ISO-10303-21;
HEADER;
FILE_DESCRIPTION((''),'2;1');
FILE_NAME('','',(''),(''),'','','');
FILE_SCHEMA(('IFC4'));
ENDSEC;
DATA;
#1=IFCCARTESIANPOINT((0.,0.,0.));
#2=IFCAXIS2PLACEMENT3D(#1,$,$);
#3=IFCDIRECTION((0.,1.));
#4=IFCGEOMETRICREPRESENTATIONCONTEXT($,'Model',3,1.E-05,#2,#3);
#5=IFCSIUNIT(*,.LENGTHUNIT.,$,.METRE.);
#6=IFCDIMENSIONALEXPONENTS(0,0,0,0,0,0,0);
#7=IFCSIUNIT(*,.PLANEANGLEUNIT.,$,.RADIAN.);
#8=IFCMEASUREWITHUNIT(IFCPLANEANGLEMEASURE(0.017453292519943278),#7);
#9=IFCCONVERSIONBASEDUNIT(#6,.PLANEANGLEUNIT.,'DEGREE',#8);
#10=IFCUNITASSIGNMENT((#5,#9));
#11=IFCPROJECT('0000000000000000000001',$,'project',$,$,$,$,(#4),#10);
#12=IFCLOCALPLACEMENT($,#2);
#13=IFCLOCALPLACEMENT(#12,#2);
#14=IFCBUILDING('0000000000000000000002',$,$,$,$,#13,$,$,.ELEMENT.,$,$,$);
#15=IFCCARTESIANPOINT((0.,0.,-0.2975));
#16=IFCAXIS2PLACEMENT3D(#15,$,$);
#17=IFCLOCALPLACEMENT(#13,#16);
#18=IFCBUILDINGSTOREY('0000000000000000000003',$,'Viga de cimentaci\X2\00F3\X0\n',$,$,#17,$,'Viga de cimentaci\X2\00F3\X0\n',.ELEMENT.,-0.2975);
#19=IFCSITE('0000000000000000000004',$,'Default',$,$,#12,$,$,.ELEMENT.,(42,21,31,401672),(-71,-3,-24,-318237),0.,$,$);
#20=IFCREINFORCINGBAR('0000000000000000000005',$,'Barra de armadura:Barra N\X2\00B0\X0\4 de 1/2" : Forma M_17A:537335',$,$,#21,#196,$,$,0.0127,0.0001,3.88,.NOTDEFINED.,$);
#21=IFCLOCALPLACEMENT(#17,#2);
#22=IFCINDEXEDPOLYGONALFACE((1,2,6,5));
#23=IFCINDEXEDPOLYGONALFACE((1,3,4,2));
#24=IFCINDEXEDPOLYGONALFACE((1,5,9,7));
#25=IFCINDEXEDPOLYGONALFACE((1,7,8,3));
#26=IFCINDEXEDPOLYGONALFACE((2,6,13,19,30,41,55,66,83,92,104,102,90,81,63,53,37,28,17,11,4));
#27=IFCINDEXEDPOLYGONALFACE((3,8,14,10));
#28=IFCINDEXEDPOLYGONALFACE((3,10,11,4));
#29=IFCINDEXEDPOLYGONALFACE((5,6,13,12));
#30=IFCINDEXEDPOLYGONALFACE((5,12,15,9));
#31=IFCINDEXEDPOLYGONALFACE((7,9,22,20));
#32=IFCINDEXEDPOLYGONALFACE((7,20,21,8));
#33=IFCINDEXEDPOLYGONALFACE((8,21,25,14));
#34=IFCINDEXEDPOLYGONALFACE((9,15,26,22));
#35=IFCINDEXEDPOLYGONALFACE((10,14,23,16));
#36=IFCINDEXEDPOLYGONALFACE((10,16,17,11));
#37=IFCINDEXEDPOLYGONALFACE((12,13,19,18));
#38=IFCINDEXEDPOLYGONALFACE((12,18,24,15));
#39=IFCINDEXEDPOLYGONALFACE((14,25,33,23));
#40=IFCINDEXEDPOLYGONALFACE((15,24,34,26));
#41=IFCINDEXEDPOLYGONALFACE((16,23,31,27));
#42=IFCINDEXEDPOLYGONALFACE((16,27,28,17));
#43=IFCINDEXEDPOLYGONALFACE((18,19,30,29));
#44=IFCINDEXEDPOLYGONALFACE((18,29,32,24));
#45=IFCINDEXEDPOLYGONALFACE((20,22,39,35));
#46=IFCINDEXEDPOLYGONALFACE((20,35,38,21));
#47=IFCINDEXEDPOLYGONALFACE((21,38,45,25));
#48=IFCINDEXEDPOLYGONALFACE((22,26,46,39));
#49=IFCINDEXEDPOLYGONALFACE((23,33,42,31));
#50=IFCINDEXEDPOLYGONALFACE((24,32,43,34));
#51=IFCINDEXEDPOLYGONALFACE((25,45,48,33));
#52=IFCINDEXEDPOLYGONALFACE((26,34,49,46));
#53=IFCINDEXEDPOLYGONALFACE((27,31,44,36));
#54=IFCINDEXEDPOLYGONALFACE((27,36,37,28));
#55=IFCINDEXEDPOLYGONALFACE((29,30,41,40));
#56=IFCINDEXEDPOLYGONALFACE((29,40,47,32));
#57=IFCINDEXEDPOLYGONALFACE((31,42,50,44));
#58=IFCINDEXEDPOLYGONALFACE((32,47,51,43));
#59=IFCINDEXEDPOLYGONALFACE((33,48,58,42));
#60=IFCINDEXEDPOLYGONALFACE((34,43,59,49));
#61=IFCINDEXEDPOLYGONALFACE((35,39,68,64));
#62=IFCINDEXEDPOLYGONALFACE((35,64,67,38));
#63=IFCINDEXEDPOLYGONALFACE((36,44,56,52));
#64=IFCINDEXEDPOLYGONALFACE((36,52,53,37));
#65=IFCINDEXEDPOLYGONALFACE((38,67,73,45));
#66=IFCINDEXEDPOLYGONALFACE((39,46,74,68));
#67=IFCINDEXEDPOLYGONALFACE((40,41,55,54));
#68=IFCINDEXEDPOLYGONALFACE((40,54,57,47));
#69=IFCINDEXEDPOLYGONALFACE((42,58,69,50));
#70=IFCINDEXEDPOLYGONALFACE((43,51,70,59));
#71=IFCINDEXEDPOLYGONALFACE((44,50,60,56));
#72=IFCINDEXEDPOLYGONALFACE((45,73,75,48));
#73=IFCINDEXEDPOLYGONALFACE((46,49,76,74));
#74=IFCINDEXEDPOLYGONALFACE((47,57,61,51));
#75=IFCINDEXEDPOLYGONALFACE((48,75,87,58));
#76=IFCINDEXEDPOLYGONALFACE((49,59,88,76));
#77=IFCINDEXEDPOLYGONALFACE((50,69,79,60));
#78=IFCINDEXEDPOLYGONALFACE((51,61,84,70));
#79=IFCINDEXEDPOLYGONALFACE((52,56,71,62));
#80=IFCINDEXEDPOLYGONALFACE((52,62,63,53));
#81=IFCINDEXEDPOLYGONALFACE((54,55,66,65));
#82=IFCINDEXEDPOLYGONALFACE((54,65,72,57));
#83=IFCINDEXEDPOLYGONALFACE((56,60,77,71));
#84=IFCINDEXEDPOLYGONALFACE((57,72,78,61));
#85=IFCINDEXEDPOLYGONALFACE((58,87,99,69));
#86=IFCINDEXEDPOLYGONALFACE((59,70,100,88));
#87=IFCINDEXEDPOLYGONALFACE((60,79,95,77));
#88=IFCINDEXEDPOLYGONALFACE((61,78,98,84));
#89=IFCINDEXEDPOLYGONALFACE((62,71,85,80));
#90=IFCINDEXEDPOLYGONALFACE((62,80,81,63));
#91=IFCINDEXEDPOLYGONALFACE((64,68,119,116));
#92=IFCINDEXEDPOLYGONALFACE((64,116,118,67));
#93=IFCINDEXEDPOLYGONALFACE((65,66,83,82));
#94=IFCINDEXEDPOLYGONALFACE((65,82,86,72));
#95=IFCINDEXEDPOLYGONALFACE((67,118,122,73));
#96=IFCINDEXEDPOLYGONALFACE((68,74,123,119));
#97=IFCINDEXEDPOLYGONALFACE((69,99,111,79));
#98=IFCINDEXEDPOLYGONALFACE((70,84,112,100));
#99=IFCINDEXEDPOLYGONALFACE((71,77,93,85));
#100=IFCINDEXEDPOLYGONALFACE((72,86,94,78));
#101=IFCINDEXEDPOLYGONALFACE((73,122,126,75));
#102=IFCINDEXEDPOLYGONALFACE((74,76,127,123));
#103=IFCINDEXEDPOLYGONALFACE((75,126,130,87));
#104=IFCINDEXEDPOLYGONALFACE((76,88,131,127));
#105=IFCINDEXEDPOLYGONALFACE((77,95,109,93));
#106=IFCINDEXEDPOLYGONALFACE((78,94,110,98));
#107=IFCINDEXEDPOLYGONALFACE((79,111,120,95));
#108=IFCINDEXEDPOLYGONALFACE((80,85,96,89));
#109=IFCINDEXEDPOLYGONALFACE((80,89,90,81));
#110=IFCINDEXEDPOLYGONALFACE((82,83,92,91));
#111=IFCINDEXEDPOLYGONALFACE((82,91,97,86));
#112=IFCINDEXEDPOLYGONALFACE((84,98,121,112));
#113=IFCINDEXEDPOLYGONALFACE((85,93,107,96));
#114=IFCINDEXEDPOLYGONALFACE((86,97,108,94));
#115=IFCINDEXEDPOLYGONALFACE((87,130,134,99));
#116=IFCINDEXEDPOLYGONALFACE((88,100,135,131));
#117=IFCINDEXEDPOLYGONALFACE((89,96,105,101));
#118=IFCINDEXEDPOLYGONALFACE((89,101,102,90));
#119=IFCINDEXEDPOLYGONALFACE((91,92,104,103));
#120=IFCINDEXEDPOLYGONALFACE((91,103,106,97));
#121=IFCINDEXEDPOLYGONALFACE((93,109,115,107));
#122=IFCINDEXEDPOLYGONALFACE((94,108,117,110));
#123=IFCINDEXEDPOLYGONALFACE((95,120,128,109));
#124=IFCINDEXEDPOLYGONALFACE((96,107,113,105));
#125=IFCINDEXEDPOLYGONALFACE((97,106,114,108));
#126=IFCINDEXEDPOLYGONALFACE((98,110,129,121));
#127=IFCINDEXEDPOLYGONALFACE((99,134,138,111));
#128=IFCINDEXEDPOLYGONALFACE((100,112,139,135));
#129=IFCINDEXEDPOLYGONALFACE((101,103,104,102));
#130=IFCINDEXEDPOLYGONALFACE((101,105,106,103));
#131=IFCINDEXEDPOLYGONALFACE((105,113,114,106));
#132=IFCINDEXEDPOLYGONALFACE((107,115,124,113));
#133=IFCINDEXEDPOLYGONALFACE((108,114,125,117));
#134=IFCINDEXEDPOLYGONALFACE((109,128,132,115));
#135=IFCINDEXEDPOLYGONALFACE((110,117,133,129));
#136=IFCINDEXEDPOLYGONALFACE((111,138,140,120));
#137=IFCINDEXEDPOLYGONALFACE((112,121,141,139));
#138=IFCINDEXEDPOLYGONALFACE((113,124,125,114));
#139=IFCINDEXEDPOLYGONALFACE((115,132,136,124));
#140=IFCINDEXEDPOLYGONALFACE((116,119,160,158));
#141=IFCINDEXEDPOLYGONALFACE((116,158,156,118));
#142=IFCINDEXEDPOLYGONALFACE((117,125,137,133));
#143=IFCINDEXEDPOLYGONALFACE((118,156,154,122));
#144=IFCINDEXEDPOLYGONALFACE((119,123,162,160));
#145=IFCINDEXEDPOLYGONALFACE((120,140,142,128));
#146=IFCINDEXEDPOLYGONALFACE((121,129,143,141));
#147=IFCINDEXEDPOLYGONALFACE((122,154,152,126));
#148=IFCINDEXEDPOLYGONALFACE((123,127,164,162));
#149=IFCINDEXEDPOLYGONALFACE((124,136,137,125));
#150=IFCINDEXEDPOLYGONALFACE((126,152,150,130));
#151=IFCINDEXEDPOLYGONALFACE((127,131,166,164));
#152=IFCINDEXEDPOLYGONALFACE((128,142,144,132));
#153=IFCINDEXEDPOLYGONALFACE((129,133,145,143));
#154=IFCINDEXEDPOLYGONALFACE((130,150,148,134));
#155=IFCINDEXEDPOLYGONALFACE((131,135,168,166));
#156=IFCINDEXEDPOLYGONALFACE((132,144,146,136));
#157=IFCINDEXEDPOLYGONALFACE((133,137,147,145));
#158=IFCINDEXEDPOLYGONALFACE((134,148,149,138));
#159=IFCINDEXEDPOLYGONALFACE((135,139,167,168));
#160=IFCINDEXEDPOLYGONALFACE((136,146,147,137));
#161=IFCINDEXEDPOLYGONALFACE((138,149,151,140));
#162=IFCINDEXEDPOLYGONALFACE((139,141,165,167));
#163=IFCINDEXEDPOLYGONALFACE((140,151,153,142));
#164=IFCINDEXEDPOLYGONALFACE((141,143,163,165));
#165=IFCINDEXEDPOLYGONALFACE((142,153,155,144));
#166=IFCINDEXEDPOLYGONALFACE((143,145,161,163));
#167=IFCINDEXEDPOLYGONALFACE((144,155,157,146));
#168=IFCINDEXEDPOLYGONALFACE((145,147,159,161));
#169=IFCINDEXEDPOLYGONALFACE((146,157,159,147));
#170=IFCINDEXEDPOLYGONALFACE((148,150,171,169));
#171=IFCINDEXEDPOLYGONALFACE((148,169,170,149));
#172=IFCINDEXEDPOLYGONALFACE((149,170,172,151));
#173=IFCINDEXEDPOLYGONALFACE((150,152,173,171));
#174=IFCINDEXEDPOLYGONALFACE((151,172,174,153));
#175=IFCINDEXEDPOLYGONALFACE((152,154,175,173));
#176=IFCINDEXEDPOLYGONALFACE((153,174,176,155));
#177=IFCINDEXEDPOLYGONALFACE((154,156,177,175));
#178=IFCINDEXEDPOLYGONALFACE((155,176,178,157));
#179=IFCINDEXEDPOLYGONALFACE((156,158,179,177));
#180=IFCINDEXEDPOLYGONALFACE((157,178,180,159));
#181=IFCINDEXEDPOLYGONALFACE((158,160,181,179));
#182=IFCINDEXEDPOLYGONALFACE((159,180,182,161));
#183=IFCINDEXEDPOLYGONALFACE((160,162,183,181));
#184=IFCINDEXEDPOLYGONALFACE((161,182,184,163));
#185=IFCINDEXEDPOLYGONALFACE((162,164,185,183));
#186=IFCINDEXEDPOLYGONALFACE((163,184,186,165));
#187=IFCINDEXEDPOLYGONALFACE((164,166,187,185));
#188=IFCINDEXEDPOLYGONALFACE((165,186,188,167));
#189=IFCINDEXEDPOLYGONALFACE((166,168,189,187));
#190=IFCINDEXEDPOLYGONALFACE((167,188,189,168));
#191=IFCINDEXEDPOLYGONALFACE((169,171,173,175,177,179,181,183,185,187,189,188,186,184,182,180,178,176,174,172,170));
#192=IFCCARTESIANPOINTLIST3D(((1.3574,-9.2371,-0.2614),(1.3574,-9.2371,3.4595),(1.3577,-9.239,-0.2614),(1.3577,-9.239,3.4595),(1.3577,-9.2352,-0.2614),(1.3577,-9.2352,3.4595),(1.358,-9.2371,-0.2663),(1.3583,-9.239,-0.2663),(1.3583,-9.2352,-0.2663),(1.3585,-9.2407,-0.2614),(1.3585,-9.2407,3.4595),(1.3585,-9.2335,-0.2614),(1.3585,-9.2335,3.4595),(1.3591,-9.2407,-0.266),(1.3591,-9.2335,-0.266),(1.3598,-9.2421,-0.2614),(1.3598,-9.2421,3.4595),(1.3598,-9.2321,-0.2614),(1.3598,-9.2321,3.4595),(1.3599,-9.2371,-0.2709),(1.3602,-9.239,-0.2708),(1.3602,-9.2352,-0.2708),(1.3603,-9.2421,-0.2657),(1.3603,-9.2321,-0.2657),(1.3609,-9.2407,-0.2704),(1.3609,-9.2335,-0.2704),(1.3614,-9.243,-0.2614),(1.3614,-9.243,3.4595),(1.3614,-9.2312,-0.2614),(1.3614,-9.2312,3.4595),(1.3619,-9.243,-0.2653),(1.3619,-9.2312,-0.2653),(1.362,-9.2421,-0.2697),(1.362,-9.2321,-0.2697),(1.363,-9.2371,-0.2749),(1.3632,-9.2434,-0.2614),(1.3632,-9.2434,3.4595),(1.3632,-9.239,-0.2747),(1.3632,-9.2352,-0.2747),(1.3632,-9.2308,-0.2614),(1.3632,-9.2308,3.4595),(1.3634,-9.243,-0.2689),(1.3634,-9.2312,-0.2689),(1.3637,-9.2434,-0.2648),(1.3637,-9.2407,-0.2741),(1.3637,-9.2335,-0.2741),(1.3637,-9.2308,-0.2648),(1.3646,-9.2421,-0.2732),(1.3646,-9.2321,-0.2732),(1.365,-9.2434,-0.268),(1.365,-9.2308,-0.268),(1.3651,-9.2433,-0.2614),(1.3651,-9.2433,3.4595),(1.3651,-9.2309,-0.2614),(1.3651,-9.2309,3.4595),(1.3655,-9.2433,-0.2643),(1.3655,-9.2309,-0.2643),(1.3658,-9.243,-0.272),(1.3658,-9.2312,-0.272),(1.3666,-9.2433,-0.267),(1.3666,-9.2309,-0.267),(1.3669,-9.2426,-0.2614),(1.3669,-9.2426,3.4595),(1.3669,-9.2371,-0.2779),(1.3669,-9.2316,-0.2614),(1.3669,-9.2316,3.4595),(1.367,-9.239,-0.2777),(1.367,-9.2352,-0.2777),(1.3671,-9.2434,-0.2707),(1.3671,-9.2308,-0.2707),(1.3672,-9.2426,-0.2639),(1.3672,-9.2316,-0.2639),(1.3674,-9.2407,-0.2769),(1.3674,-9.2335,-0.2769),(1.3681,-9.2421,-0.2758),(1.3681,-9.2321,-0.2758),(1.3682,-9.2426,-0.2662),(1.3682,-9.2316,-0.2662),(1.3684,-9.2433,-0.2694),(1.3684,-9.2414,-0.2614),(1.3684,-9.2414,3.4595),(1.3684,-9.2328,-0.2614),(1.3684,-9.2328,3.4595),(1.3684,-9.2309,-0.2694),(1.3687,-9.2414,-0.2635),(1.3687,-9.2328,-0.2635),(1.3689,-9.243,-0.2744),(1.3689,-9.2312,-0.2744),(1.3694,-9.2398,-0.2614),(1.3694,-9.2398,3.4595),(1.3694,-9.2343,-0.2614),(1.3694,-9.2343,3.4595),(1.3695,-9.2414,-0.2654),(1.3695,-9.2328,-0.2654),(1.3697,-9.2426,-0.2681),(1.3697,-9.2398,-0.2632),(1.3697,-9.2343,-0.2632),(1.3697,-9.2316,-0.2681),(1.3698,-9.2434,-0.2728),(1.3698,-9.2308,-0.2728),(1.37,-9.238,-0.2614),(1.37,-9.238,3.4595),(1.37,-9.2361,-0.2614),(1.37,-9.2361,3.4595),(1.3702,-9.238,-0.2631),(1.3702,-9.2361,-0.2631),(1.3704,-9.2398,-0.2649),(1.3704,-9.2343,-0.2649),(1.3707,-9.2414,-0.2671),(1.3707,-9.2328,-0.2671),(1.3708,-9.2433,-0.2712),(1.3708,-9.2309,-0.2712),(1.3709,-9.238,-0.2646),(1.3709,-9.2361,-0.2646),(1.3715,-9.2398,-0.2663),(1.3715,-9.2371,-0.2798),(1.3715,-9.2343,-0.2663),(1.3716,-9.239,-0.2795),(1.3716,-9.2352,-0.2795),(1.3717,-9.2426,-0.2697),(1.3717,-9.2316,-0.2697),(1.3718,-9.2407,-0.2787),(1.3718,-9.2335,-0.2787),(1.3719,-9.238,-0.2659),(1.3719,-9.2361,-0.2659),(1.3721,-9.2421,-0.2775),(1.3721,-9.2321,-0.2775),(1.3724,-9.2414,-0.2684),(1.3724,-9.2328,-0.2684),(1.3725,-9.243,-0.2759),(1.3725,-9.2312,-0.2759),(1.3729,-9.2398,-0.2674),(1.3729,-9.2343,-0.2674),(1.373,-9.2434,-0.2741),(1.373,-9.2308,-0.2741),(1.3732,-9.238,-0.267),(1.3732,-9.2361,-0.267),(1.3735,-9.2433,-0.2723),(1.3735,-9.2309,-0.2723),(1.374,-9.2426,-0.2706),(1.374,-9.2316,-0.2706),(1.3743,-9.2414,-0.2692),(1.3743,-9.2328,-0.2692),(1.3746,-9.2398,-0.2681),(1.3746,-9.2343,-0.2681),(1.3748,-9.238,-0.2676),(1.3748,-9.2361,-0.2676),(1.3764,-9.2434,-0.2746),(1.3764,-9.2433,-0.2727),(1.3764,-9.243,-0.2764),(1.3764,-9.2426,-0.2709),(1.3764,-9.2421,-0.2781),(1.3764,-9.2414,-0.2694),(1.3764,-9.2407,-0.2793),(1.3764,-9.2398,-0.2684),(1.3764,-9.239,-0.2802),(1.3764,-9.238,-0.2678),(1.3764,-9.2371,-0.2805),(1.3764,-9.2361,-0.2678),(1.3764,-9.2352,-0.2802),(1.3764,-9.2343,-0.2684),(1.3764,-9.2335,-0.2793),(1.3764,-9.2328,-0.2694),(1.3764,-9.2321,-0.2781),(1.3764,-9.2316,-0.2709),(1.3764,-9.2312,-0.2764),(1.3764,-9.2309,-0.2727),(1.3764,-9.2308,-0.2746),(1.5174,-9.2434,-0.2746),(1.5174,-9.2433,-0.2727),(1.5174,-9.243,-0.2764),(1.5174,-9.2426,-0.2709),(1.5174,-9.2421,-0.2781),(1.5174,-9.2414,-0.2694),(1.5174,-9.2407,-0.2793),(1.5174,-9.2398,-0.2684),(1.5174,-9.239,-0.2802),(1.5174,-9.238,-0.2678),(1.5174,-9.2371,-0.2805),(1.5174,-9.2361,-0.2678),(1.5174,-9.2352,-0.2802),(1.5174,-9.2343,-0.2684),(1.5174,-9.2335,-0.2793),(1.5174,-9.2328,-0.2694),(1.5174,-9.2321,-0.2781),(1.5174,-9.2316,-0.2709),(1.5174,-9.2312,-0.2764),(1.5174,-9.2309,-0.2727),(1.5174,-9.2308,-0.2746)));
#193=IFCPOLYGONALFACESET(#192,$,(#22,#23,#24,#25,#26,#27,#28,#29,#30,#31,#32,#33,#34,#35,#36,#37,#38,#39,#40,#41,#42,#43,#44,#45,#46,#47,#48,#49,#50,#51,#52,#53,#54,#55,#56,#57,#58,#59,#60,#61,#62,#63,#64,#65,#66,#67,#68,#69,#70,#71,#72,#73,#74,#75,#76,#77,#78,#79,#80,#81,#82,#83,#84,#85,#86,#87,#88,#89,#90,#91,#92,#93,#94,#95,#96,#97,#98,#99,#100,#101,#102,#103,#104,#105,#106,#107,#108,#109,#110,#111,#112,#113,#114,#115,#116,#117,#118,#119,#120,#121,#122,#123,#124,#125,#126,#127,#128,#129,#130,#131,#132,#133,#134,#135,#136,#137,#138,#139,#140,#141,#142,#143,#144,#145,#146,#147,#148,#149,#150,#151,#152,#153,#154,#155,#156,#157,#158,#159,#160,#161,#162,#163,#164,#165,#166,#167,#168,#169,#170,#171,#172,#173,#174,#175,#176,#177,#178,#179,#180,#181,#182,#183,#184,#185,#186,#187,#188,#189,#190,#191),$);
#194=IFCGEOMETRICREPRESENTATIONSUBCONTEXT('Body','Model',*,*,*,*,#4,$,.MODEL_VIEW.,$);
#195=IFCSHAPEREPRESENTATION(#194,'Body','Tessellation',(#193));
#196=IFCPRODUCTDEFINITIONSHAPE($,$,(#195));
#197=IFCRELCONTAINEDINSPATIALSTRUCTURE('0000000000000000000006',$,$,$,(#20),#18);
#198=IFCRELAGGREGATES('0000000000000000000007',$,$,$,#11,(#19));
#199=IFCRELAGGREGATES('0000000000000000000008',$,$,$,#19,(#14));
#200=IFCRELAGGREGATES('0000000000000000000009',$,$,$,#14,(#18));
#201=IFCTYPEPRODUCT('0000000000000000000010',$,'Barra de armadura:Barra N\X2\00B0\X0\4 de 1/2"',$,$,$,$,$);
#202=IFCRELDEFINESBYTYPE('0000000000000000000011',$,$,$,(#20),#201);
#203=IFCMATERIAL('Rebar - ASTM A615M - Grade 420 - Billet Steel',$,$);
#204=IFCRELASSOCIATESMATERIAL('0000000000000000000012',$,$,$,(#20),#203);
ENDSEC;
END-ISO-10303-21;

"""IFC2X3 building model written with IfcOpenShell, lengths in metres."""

from ifc_helpers import new_model, entity, si_unit, converted_unit, direction, frame, origin, place, context, subcontext, project, spatial, material, type_object, element, save


model = new_model("IFC2X3")

# Units and contexts
model_context = context("Model", 3, precision=1e-05, world=origin(), true_north=direction((0.0, 1.0)))
body_context = subcontext(model_context, "Body", "Model", "MODEL_VIEW")
ifc_project = project(units=[si_unit("LENGTHUNIT", "METRE"), converted_unit("PLANEANGLEUNIT", "DEGREE", entity("IfcPlaneAngleMeasure", 0.017453292519943278), si_unit("PLANEANGLEUNIT", "RADIAN"), dimensions=[0, 0, 0, 0, 0, 0, 0])], contexts=[model_context])

# Site, building, storey
site_placement = place(None, origin())
site = spatial("IfcSite", under=ifc_project, at=site_placement, Name="Default", CompositionType="ELEMENT", RefLatitude=(42, 21, 31, 401672), RefLongitude=(-71, -3, -24, -318237), RefElevation=0.0)
building_placement = place(site_placement, origin())
building = spatial("IfcBuilding", under=site, at=building_placement, CompositionType="ELEMENT")
storey_placement = place(building_placement, frame((0.0, 0.0, -0.2975)))
storey = spatial("IfcBuildingStorey", under=building, at=storey_placement, Name="Viga de cimentación", LongName="Viga de cimentación", CompositionType="ELEMENT", Elevation=-0.2975)

# Reinforcing bar
ifc_material = material(Name="Rebar - ASTM A615M - Grade 420 - Billet Steel")
type_product_1 = type_object("IfcTypeProduct", Name="Barra de armadura:Barra N°4 de 1/2\"")
reinforcing_bar_1_placement = place(storey_placement, origin())
element("IfcReinforcingBar", 1, at=reinforcing_bar_1_placement, inside=storey, type_object=type_product_1, material=ifc_material, Name="Barra de armadura:Barra N°4 de 1/2\" : Forma M_17A:537335", BarLength=3.88, BarRole="NOTDEFINED", CrossSectionArea=0.0001, NominalDiameter=0.0127, context=body_context, shape_type="AdvancedSweptSolid", body=[
    entity("IfcSweptDiskSolid", entity("IfcCompositeCurve", [entity("IfcCompositeCurveSegment", "CONTINUOUS", True, entity("IfcPolyline", [entity("IfcCartesianPoint", [1.3637, -9.2371, 3.4595]), entity("IfcCartesianPoint", [1.3637, -9.2371, -0.2614])])), entity("IfcCompositeCurveSegment", "CONTINUOUS", True, entity("IfcTrimmedCurve", entity("IfcCircle", entity("IfcAxis2Placement3D", entity("IfcCartesianPoint", [1.3764, -9.2371, -0.2614]), entity("IfcDirection", [0.0, -1.0, 0.0]), entity("IfcDirection", [0.0, 0.0, -1.0])), 0.0127), [entity("IfcParameterValue", 270.0)], [entity("IfcParameterValue", 360.0)], True, "PARAMETER")), entity("IfcCompositeCurveSegment", "CONTINUOUS", True, entity("IfcPolyline", [entity("IfcCartesianPoint", [1.3764, -9.2371, -0.2741]), entity("IfcCartesianPoint", [1.5174, -9.2371, -0.2741])]))], False), 0.0063, None, 0.0, 92.0),
])

save(model, "model.ifc")
